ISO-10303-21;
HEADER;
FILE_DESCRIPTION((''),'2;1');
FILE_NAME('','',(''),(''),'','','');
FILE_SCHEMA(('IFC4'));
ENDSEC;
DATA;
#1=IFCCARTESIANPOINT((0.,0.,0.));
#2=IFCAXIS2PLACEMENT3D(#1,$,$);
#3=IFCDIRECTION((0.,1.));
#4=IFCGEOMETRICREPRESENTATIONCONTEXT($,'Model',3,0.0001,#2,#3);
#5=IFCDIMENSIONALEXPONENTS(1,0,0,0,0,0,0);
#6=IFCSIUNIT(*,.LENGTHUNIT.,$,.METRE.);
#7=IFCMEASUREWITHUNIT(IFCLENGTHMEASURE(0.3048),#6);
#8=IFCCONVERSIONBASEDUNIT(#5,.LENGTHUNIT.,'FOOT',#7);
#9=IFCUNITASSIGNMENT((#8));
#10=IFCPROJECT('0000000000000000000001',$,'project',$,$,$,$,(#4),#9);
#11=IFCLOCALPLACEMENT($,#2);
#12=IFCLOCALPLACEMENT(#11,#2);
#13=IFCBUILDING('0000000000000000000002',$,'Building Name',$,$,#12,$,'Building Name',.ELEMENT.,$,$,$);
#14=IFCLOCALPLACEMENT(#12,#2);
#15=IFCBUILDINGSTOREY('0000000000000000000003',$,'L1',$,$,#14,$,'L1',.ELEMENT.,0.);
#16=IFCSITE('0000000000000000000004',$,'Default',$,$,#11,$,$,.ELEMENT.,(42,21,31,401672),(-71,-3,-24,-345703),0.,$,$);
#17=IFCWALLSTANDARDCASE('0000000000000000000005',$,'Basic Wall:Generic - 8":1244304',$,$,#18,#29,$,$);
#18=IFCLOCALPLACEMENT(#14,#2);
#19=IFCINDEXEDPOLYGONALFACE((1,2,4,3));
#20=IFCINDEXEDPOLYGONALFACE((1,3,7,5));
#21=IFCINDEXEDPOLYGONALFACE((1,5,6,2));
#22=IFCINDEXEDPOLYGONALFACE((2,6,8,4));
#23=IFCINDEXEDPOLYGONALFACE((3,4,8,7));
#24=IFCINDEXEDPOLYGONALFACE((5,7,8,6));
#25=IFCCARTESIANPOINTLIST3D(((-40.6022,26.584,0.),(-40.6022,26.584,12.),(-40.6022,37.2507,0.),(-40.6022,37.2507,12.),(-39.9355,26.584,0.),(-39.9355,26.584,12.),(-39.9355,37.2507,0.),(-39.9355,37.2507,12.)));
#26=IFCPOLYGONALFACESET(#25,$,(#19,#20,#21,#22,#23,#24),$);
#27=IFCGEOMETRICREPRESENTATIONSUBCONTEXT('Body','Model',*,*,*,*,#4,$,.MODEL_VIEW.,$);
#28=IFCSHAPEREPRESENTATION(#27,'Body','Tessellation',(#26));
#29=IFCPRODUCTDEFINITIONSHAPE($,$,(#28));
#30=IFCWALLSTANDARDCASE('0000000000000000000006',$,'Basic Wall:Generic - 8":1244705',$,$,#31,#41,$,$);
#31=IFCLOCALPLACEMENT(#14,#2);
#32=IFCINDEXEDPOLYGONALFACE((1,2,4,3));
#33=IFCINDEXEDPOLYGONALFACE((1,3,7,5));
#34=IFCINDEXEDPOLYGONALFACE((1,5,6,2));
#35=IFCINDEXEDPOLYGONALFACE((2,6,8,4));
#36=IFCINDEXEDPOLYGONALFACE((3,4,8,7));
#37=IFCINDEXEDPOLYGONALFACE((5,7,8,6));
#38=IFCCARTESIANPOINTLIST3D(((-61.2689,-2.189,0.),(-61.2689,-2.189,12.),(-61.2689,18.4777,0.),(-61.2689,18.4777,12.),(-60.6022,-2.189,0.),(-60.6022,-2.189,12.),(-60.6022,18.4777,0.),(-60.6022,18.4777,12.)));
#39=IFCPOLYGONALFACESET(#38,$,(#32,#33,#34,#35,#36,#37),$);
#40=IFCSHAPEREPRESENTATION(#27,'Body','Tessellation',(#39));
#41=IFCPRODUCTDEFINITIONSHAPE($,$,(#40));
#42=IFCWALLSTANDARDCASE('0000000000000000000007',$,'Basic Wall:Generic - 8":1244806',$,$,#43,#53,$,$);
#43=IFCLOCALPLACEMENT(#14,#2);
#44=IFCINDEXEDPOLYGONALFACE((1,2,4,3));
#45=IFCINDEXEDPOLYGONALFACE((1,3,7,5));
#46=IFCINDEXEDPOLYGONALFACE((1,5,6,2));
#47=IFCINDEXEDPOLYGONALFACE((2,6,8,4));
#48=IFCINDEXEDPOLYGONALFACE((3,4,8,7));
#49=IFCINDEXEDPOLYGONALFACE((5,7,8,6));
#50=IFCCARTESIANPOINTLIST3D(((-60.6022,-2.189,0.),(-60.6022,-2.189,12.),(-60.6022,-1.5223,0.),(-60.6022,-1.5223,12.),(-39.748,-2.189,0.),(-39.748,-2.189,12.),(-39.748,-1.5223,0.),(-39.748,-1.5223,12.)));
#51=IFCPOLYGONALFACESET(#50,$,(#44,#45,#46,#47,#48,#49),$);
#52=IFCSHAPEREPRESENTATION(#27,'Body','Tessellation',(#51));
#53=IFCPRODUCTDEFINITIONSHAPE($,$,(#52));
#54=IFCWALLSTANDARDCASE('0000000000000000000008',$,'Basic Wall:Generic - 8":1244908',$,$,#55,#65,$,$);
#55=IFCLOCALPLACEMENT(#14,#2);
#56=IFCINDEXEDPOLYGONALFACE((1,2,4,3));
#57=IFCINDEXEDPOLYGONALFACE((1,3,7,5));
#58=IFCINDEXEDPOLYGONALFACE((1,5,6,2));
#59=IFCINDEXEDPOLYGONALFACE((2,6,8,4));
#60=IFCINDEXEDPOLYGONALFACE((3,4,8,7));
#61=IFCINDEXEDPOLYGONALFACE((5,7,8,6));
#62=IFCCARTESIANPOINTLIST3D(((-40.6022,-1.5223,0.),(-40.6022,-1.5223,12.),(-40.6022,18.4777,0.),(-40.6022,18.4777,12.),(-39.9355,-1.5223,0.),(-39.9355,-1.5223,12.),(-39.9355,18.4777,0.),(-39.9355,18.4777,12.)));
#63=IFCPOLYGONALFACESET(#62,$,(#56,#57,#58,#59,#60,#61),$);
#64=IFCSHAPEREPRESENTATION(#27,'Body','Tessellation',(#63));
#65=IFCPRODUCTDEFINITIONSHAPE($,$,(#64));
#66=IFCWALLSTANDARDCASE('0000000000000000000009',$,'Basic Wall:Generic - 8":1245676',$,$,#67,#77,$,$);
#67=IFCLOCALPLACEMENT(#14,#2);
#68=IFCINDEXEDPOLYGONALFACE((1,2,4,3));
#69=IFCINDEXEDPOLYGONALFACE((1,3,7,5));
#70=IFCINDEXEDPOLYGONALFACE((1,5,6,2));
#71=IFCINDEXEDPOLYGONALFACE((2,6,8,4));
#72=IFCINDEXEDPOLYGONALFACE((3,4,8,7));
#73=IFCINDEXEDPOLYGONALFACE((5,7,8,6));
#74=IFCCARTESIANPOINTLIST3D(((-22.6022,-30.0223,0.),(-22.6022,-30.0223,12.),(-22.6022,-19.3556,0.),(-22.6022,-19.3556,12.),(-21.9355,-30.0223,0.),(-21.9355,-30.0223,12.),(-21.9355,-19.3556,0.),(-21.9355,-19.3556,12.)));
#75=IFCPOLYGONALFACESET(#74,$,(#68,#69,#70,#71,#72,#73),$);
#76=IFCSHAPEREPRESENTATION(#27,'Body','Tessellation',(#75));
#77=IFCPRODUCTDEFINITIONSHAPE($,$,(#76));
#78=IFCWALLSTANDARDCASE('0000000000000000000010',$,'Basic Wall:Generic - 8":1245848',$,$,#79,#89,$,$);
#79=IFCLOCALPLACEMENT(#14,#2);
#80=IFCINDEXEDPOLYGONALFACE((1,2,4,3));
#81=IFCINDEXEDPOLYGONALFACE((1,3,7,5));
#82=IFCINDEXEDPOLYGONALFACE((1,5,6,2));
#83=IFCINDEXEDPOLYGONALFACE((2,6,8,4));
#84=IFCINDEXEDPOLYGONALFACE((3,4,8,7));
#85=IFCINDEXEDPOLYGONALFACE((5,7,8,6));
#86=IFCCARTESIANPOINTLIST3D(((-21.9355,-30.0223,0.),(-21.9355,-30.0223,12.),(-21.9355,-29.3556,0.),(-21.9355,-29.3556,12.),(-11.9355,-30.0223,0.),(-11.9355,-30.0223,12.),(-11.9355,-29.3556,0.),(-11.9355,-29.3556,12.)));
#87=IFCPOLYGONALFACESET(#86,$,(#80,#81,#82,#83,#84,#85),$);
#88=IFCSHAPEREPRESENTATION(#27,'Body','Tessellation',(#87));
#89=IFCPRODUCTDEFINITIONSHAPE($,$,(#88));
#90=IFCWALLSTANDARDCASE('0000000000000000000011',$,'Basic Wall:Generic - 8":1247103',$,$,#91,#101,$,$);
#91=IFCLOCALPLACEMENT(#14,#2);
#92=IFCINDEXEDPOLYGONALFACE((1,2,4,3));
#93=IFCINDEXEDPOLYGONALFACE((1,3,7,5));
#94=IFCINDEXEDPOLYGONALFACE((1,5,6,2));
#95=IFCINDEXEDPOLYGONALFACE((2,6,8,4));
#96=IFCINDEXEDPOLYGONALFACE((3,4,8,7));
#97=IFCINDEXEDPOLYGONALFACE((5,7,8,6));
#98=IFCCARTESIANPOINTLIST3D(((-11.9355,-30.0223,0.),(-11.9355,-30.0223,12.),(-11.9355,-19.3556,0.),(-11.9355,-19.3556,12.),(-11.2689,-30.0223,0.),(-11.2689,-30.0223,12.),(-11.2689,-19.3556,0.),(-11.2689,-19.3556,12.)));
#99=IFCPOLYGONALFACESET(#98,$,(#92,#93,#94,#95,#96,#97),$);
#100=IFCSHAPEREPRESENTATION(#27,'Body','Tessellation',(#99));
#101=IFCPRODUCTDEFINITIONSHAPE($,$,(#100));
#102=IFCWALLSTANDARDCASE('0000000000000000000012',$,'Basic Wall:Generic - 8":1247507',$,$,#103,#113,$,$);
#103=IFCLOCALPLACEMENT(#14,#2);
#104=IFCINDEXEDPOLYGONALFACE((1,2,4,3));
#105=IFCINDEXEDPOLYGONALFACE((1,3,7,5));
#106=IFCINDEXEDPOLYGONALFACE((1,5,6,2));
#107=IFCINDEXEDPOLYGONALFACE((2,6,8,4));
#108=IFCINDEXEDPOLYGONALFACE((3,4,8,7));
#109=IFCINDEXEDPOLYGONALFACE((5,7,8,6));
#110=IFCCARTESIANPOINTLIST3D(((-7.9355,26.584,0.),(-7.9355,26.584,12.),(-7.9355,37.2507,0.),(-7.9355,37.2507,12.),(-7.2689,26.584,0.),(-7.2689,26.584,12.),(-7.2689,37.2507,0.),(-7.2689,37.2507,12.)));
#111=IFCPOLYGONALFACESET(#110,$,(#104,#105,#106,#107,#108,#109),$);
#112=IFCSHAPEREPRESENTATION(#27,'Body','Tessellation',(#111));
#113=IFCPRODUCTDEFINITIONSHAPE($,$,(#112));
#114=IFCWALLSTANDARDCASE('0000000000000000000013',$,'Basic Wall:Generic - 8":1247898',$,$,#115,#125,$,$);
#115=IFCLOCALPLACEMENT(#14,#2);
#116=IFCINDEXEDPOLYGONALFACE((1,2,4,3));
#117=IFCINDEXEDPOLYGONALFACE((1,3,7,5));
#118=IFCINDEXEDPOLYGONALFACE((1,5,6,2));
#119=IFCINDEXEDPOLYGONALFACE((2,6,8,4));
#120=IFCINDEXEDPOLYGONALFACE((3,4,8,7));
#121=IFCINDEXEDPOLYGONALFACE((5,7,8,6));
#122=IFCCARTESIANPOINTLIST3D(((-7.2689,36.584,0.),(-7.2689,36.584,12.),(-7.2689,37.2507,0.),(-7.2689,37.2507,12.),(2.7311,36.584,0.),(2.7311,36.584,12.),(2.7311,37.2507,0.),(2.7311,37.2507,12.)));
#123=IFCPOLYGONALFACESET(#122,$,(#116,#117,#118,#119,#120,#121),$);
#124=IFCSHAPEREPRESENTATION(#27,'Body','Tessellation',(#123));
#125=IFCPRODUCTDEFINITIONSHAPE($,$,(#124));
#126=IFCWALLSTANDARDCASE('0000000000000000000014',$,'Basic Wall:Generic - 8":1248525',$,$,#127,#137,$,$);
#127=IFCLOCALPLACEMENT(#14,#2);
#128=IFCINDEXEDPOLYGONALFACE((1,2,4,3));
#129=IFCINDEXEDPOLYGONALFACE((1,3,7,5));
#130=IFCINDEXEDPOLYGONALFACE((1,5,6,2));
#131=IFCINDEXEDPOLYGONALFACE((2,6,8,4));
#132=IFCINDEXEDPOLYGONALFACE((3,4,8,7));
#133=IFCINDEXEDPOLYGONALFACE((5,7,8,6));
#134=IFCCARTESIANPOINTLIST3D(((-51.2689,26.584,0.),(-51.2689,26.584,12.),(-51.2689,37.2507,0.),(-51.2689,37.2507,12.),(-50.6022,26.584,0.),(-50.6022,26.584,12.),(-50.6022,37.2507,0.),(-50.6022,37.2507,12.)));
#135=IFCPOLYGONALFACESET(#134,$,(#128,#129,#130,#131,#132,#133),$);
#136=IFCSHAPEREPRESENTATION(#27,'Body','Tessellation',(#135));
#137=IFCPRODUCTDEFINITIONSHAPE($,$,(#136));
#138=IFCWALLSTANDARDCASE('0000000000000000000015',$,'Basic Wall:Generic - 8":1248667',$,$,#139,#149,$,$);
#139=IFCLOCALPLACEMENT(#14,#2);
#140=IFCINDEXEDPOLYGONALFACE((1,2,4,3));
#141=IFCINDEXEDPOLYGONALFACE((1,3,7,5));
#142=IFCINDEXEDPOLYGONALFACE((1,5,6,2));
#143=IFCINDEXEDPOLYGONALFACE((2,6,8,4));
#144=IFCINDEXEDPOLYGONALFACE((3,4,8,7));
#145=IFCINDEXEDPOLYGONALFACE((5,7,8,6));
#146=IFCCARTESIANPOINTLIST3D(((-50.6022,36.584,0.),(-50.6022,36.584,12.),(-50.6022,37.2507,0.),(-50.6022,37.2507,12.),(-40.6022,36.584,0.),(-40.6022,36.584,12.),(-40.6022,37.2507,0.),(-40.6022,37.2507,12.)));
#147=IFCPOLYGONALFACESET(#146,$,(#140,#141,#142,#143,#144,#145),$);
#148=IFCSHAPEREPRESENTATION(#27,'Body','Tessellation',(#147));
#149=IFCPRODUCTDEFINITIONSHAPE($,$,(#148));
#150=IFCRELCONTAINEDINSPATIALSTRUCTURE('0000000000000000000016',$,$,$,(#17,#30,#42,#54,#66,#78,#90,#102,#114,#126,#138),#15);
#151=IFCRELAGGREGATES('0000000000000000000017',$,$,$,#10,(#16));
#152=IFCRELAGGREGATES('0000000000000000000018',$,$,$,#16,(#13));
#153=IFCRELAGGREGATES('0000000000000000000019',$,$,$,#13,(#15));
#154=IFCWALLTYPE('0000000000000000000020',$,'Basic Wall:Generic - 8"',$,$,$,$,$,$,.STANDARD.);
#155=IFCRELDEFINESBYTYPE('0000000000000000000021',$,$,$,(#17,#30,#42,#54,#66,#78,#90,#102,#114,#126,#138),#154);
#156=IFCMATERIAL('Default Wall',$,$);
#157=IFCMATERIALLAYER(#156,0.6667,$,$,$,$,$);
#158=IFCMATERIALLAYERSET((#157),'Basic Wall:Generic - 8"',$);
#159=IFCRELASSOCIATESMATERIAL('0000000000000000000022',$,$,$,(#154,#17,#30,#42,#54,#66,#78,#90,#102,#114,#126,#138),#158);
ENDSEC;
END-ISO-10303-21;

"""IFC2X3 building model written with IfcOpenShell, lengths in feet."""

from ifc_helpers import new_model, entity, si_unit, converted_unit, direction, frame, frame_2d, origin, place, context, subcontext, project, spatial, rectangle, extrude, material, layer, layer_set, layer_usage, type_object, element, save


model = new_model("IFC2X3")

# Units and contexts
model_context = context("Model", 3, precision=0.0001, world=origin(), true_north=direction((0.0, 1.0)))
body_context = subcontext(model_context, "Body", "Model", "MODEL_VIEW")
ifc_project = project(units=[converted_unit("LENGTHUNIT", "FOOT", entity("IfcLengthMeasure", 0.3048), si_unit("LENGTHUNIT", "METRE"), dimensions=[1, 0, 0, 0, 0, 0, 0])], contexts=[model_context])

# Site, building, storey
site_placement = place(None, origin())
site = spatial("IfcSite", under=ifc_project, at=site_placement, Name="Default", CompositionType="ELEMENT", RefLatitude=(42, 21, 31, 401672), RefLongitude=(-71, -3, -24, -345703), RefElevation=0.0)
building_placement = place(site_placement, origin())
building = spatial("IfcBuilding", under=site, at=building_placement, Name="Building Name", LongName="Building Name", CompositionType="ELEMENT")
storey_placement = place(building_placement, origin())
storey = spatial("IfcBuildingStorey", under=building, at=storey_placement, Name="L1", LongName="L1", CompositionType="ELEMENT", Elevation=0.0)

# Walls
ifc_material_1 = material(Name="Default Wall")
ifc_layer_1 = layer(ifc_material_1, 0.6667)
ifc_layer_set_1 = layer_set([ifc_layer_1], Name="Basic Wall:Generic - 8\"")
wall_type_1 = type_object("IfcWallType", Name="Basic Wall:Generic - 8\"", PredefinedType="STANDARD", material=ifc_layer_set_1)
ifc_layer_usage_1 = layer_usage(ifc_layer_set_1, "AXIS2", "NEGATIVE", 0.3333)
wall_1_placement = place(storey_placement, frame((-40.2689, 26.584, 0.0), z_axis=(0.0, 0.0, 1.0), x_axis=(0.0, 1.0, 0.0)))
element("IfcWallStandardCase", 1, at=wall_1_placement, inside=storey, type_object=wall_type_1, material=ifc_layer_usage_1, Name="Basic Wall:Generic - 8\":1244304", context=body_context, shape_type="SweptSolid", body=[
    extrude(rectangle(XDim=10.6667, YDim=0.6667, at=frame_2d((5.3333, 0.0), x_axis=(-1.0, 0.0))), origin(), (0.0, 0.0, 1.0), 12.0),
])
ifc_layer_usage_2 = layer_usage(ifc_layer_set_1, "AXIS2", "NEGATIVE", 0.3333)
wall_2_placement = place(storey_placement, frame((-60.9355, 18.4777, 0.0), z_axis=(0.0, 0.0, 1.0), x_axis=(0.0, -1.0, 0.0)))
element("IfcWallStandardCase", 2, at=wall_2_placement, inside=storey, type_object=wall_type_1, material=ifc_layer_usage_2, Name="Basic Wall:Generic - 8\":1244705", context=body_context, shape_type="SweptSolid", body=[
    extrude(rectangle(XDim=20.6667, YDim=0.6667, at=frame_2d((10.3333, 0.0), x_axis=(-1.0, 0.0))), origin(), (0.0, 0.0, 1.0), 12.0),
])
ifc_layer_usage_3 = layer_usage(ifc_layer_set_1, "AXIS2", "NEGATIVE", 0.3333)
wall_3_placement = place(storey_placement, frame((-60.6022, -1.8556, 0.0)))
element("IfcWallStandardCase", 3, at=wall_3_placement, inside=storey, type_object=wall_type_1, material=ifc_layer_usage_3, Name="Basic Wall:Generic - 8\":1244806", context=body_context, shape_type="SweptSolid", body=[
    extrude(rectangle(XDim=20.8542, YDim=0.6667, at=frame_2d((10.4271, 0.0), x_axis=(-1.0, 0.0))), origin(), (0.0, 0.0, 1.0), 12.0),
])
ifc_layer_usage_4 = layer_usage(ifc_layer_set_1, "AXIS2", "POSITIVE", -0.3333)
wall_4_placement = place(storey_placement, frame((-40.2689, 18.4777, 0.0), z_axis=(0.0, 0.0, 1.0), x_axis=(0.0, -1.0, 0.0)))
element("IfcWallStandardCase", 4, at=wall_4_placement, inside=storey, type_object=wall_type_1, material=ifc_layer_usage_4, Name="Basic Wall:Generic - 8\":1244908", context=body_context, shape_type="SweptSolid", body=[
    extrude(rectangle(XDim=20.0, YDim=0.6667, at=frame_2d((10.0, 0.0), x_axis=(-1.0, 0.0))), origin(), (0.0, 0.0, 1.0), 12.0),
])
ifc_layer_usage_5 = layer_usage(ifc_layer_set_1, "AXIS2", "POSITIVE", -0.3333)
wall_5_placement = place(storey_placement, frame((-22.2689, -19.3556, 0.0), z_axis=(0.0, 0.0, 1.0), x_axis=(0.0, -1.0, 0.0)))
element("IfcWallStandardCase", 5, at=wall_5_placement, inside=storey, type_object=wall_type_1, material=ifc_layer_usage_5, Name="Basic Wall:Generic - 8\":1245676", context=body_context, shape_type="SweptSolid", body=[
    extrude(rectangle(XDim=10.6667, YDim=0.6667, at=frame_2d((5.3333, 0.0), x_axis=(-1.0, 0.0))), origin(), (0.0, 0.0, 1.0), 12.0),
])
ifc_layer_usage_6 = layer_usage(ifc_layer_set_1, "AXIS2", "POSITIVE", -0.3333)
wall_6_placement = place(storey_placement, frame((-21.9355, -29.689, 0.0)))
element("IfcWallStandardCase", 6, at=wall_6_placement, inside=storey, type_object=wall_type_1, material=ifc_layer_usage_6, Name="Basic Wall:Generic - 8\":1245848", context=body_context, shape_type="SweptSolid", body=[
    extrude(rectangle(XDim=10.0, YDim=0.6667, at=frame_2d((5.0, 0.0), x_axis=(-1.0, 0.0))), origin(), (0.0, 0.0, 1.0), 12.0),
])
ifc_layer_usage_7 = layer_usage(ifc_layer_set_1, "AXIS2", "NEGATIVE", 0.3333)
wall_7_placement = place(storey_placement, frame((-11.6022, -19.3556, 0.0), z_axis=(0.0, 0.0, 1.0), x_axis=(0.0, -1.0, 0.0)))
element("IfcWallStandardCase", 7, at=wall_7_placement, inside=storey, type_object=wall_type_1, material=ifc_layer_usage_7, Name="Basic Wall:Generic - 8\":1247103", context=body_context, shape_type="SweptSolid", body=[
    extrude(rectangle(XDim=10.6667, YDim=0.6667, at=frame_2d((5.3333, 0.0), x_axis=(-1.0, 0.0))), origin(), (0.0, 0.0, 1.0), 12.0),
])
ifc_layer_usage_8 = layer_usage(ifc_layer_set_1, "AXIS2", "POSITIVE", -0.3333)
wall_8_placement = place(storey_placement, frame((-7.6022, 37.2507, 0.0), z_axis=(0.0, 0.0, 1.0), x_axis=(0.0, -1.0, 0.0)))
element("IfcWallStandardCase", 8, at=wall_8_placement, inside=storey, type_object=wall_type_1, material=ifc_layer_usage_8, Name="Basic Wall:Generic - 8\":1247507", context=body_context, shape_type="SweptSolid", body=[
    extrude(rectangle(XDim=10.6667, YDim=0.6667, at=frame_2d((5.3333, 0.0), x_axis=(-1.0, 0.0))), origin(), (0.0, 0.0, 1.0), 12.0),
])
ifc_layer_usage_9 = layer_usage(ifc_layer_set_1, "AXIS2", "NEGATIVE", 0.3333)
wall_9_placement = place(storey_placement, frame((-7.2689, 36.9174, 0.0)))
element("IfcWallStandardCase", 9, at=wall_9_placement, inside=storey, type_object=wall_type_1, material=ifc_layer_usage_9, Name="Basic Wall:Generic - 8\":1247898", context=body_context, shape_type="SweptSolid", body=[
    extrude(rectangle(XDim=10.0, YDim=0.6667, at=frame_2d((5.0, 0.0), x_axis=(-1.0, 0.0))), origin(), (0.0, 0.0, 1.0), 12.0),
])
ifc_layer_usage_10 = layer_usage(ifc_layer_set_1, "AXIS2", "NEGATIVE", 0.3333)
wall_10_placement = place(storey_placement, frame((-50.9355, 26.584, 0.0), z_axis=(0.0, 0.0, 1.0), x_axis=(0.0, 1.0, 0.0)))
element("IfcWallStandardCase", 10, at=wall_10_placement, inside=storey, type_object=wall_type_1, material=ifc_layer_usage_10, Name="Basic Wall:Generic - 8\":1248525", context=body_context, shape_type="SweptSolid", body=[
    extrude(rectangle(XDim=10.6667, YDim=0.6667, at=frame_2d((5.3333, 0.0), x_axis=(-1.0, 0.0))), origin(), (0.0, 0.0, 1.0), 12.0),
])
ifc_layer_usage_11 = layer_usage(ifc_layer_set_1, "AXIS2", "POSITIVE", -0.3333)
wall_11_placement = place(storey_placement, frame((-50.6022, 36.9174, 0.0)))
element("IfcWallStandardCase", 11, at=wall_11_placement, inside=storey, type_object=wall_type_1, material=ifc_layer_usage_11, Name="Basic Wall:Generic - 8\":1248667", context=body_context, shape_type="SweptSolid", body=[
    extrude(rectangle(XDim=10.0, YDim=0.6667, at=frame_2d((5.0, 0.0), x_axis=(-1.0, 0.0))), origin(), (0.0, 0.0, 1.0), 12.0),
])

save(model, "model.ifc")
